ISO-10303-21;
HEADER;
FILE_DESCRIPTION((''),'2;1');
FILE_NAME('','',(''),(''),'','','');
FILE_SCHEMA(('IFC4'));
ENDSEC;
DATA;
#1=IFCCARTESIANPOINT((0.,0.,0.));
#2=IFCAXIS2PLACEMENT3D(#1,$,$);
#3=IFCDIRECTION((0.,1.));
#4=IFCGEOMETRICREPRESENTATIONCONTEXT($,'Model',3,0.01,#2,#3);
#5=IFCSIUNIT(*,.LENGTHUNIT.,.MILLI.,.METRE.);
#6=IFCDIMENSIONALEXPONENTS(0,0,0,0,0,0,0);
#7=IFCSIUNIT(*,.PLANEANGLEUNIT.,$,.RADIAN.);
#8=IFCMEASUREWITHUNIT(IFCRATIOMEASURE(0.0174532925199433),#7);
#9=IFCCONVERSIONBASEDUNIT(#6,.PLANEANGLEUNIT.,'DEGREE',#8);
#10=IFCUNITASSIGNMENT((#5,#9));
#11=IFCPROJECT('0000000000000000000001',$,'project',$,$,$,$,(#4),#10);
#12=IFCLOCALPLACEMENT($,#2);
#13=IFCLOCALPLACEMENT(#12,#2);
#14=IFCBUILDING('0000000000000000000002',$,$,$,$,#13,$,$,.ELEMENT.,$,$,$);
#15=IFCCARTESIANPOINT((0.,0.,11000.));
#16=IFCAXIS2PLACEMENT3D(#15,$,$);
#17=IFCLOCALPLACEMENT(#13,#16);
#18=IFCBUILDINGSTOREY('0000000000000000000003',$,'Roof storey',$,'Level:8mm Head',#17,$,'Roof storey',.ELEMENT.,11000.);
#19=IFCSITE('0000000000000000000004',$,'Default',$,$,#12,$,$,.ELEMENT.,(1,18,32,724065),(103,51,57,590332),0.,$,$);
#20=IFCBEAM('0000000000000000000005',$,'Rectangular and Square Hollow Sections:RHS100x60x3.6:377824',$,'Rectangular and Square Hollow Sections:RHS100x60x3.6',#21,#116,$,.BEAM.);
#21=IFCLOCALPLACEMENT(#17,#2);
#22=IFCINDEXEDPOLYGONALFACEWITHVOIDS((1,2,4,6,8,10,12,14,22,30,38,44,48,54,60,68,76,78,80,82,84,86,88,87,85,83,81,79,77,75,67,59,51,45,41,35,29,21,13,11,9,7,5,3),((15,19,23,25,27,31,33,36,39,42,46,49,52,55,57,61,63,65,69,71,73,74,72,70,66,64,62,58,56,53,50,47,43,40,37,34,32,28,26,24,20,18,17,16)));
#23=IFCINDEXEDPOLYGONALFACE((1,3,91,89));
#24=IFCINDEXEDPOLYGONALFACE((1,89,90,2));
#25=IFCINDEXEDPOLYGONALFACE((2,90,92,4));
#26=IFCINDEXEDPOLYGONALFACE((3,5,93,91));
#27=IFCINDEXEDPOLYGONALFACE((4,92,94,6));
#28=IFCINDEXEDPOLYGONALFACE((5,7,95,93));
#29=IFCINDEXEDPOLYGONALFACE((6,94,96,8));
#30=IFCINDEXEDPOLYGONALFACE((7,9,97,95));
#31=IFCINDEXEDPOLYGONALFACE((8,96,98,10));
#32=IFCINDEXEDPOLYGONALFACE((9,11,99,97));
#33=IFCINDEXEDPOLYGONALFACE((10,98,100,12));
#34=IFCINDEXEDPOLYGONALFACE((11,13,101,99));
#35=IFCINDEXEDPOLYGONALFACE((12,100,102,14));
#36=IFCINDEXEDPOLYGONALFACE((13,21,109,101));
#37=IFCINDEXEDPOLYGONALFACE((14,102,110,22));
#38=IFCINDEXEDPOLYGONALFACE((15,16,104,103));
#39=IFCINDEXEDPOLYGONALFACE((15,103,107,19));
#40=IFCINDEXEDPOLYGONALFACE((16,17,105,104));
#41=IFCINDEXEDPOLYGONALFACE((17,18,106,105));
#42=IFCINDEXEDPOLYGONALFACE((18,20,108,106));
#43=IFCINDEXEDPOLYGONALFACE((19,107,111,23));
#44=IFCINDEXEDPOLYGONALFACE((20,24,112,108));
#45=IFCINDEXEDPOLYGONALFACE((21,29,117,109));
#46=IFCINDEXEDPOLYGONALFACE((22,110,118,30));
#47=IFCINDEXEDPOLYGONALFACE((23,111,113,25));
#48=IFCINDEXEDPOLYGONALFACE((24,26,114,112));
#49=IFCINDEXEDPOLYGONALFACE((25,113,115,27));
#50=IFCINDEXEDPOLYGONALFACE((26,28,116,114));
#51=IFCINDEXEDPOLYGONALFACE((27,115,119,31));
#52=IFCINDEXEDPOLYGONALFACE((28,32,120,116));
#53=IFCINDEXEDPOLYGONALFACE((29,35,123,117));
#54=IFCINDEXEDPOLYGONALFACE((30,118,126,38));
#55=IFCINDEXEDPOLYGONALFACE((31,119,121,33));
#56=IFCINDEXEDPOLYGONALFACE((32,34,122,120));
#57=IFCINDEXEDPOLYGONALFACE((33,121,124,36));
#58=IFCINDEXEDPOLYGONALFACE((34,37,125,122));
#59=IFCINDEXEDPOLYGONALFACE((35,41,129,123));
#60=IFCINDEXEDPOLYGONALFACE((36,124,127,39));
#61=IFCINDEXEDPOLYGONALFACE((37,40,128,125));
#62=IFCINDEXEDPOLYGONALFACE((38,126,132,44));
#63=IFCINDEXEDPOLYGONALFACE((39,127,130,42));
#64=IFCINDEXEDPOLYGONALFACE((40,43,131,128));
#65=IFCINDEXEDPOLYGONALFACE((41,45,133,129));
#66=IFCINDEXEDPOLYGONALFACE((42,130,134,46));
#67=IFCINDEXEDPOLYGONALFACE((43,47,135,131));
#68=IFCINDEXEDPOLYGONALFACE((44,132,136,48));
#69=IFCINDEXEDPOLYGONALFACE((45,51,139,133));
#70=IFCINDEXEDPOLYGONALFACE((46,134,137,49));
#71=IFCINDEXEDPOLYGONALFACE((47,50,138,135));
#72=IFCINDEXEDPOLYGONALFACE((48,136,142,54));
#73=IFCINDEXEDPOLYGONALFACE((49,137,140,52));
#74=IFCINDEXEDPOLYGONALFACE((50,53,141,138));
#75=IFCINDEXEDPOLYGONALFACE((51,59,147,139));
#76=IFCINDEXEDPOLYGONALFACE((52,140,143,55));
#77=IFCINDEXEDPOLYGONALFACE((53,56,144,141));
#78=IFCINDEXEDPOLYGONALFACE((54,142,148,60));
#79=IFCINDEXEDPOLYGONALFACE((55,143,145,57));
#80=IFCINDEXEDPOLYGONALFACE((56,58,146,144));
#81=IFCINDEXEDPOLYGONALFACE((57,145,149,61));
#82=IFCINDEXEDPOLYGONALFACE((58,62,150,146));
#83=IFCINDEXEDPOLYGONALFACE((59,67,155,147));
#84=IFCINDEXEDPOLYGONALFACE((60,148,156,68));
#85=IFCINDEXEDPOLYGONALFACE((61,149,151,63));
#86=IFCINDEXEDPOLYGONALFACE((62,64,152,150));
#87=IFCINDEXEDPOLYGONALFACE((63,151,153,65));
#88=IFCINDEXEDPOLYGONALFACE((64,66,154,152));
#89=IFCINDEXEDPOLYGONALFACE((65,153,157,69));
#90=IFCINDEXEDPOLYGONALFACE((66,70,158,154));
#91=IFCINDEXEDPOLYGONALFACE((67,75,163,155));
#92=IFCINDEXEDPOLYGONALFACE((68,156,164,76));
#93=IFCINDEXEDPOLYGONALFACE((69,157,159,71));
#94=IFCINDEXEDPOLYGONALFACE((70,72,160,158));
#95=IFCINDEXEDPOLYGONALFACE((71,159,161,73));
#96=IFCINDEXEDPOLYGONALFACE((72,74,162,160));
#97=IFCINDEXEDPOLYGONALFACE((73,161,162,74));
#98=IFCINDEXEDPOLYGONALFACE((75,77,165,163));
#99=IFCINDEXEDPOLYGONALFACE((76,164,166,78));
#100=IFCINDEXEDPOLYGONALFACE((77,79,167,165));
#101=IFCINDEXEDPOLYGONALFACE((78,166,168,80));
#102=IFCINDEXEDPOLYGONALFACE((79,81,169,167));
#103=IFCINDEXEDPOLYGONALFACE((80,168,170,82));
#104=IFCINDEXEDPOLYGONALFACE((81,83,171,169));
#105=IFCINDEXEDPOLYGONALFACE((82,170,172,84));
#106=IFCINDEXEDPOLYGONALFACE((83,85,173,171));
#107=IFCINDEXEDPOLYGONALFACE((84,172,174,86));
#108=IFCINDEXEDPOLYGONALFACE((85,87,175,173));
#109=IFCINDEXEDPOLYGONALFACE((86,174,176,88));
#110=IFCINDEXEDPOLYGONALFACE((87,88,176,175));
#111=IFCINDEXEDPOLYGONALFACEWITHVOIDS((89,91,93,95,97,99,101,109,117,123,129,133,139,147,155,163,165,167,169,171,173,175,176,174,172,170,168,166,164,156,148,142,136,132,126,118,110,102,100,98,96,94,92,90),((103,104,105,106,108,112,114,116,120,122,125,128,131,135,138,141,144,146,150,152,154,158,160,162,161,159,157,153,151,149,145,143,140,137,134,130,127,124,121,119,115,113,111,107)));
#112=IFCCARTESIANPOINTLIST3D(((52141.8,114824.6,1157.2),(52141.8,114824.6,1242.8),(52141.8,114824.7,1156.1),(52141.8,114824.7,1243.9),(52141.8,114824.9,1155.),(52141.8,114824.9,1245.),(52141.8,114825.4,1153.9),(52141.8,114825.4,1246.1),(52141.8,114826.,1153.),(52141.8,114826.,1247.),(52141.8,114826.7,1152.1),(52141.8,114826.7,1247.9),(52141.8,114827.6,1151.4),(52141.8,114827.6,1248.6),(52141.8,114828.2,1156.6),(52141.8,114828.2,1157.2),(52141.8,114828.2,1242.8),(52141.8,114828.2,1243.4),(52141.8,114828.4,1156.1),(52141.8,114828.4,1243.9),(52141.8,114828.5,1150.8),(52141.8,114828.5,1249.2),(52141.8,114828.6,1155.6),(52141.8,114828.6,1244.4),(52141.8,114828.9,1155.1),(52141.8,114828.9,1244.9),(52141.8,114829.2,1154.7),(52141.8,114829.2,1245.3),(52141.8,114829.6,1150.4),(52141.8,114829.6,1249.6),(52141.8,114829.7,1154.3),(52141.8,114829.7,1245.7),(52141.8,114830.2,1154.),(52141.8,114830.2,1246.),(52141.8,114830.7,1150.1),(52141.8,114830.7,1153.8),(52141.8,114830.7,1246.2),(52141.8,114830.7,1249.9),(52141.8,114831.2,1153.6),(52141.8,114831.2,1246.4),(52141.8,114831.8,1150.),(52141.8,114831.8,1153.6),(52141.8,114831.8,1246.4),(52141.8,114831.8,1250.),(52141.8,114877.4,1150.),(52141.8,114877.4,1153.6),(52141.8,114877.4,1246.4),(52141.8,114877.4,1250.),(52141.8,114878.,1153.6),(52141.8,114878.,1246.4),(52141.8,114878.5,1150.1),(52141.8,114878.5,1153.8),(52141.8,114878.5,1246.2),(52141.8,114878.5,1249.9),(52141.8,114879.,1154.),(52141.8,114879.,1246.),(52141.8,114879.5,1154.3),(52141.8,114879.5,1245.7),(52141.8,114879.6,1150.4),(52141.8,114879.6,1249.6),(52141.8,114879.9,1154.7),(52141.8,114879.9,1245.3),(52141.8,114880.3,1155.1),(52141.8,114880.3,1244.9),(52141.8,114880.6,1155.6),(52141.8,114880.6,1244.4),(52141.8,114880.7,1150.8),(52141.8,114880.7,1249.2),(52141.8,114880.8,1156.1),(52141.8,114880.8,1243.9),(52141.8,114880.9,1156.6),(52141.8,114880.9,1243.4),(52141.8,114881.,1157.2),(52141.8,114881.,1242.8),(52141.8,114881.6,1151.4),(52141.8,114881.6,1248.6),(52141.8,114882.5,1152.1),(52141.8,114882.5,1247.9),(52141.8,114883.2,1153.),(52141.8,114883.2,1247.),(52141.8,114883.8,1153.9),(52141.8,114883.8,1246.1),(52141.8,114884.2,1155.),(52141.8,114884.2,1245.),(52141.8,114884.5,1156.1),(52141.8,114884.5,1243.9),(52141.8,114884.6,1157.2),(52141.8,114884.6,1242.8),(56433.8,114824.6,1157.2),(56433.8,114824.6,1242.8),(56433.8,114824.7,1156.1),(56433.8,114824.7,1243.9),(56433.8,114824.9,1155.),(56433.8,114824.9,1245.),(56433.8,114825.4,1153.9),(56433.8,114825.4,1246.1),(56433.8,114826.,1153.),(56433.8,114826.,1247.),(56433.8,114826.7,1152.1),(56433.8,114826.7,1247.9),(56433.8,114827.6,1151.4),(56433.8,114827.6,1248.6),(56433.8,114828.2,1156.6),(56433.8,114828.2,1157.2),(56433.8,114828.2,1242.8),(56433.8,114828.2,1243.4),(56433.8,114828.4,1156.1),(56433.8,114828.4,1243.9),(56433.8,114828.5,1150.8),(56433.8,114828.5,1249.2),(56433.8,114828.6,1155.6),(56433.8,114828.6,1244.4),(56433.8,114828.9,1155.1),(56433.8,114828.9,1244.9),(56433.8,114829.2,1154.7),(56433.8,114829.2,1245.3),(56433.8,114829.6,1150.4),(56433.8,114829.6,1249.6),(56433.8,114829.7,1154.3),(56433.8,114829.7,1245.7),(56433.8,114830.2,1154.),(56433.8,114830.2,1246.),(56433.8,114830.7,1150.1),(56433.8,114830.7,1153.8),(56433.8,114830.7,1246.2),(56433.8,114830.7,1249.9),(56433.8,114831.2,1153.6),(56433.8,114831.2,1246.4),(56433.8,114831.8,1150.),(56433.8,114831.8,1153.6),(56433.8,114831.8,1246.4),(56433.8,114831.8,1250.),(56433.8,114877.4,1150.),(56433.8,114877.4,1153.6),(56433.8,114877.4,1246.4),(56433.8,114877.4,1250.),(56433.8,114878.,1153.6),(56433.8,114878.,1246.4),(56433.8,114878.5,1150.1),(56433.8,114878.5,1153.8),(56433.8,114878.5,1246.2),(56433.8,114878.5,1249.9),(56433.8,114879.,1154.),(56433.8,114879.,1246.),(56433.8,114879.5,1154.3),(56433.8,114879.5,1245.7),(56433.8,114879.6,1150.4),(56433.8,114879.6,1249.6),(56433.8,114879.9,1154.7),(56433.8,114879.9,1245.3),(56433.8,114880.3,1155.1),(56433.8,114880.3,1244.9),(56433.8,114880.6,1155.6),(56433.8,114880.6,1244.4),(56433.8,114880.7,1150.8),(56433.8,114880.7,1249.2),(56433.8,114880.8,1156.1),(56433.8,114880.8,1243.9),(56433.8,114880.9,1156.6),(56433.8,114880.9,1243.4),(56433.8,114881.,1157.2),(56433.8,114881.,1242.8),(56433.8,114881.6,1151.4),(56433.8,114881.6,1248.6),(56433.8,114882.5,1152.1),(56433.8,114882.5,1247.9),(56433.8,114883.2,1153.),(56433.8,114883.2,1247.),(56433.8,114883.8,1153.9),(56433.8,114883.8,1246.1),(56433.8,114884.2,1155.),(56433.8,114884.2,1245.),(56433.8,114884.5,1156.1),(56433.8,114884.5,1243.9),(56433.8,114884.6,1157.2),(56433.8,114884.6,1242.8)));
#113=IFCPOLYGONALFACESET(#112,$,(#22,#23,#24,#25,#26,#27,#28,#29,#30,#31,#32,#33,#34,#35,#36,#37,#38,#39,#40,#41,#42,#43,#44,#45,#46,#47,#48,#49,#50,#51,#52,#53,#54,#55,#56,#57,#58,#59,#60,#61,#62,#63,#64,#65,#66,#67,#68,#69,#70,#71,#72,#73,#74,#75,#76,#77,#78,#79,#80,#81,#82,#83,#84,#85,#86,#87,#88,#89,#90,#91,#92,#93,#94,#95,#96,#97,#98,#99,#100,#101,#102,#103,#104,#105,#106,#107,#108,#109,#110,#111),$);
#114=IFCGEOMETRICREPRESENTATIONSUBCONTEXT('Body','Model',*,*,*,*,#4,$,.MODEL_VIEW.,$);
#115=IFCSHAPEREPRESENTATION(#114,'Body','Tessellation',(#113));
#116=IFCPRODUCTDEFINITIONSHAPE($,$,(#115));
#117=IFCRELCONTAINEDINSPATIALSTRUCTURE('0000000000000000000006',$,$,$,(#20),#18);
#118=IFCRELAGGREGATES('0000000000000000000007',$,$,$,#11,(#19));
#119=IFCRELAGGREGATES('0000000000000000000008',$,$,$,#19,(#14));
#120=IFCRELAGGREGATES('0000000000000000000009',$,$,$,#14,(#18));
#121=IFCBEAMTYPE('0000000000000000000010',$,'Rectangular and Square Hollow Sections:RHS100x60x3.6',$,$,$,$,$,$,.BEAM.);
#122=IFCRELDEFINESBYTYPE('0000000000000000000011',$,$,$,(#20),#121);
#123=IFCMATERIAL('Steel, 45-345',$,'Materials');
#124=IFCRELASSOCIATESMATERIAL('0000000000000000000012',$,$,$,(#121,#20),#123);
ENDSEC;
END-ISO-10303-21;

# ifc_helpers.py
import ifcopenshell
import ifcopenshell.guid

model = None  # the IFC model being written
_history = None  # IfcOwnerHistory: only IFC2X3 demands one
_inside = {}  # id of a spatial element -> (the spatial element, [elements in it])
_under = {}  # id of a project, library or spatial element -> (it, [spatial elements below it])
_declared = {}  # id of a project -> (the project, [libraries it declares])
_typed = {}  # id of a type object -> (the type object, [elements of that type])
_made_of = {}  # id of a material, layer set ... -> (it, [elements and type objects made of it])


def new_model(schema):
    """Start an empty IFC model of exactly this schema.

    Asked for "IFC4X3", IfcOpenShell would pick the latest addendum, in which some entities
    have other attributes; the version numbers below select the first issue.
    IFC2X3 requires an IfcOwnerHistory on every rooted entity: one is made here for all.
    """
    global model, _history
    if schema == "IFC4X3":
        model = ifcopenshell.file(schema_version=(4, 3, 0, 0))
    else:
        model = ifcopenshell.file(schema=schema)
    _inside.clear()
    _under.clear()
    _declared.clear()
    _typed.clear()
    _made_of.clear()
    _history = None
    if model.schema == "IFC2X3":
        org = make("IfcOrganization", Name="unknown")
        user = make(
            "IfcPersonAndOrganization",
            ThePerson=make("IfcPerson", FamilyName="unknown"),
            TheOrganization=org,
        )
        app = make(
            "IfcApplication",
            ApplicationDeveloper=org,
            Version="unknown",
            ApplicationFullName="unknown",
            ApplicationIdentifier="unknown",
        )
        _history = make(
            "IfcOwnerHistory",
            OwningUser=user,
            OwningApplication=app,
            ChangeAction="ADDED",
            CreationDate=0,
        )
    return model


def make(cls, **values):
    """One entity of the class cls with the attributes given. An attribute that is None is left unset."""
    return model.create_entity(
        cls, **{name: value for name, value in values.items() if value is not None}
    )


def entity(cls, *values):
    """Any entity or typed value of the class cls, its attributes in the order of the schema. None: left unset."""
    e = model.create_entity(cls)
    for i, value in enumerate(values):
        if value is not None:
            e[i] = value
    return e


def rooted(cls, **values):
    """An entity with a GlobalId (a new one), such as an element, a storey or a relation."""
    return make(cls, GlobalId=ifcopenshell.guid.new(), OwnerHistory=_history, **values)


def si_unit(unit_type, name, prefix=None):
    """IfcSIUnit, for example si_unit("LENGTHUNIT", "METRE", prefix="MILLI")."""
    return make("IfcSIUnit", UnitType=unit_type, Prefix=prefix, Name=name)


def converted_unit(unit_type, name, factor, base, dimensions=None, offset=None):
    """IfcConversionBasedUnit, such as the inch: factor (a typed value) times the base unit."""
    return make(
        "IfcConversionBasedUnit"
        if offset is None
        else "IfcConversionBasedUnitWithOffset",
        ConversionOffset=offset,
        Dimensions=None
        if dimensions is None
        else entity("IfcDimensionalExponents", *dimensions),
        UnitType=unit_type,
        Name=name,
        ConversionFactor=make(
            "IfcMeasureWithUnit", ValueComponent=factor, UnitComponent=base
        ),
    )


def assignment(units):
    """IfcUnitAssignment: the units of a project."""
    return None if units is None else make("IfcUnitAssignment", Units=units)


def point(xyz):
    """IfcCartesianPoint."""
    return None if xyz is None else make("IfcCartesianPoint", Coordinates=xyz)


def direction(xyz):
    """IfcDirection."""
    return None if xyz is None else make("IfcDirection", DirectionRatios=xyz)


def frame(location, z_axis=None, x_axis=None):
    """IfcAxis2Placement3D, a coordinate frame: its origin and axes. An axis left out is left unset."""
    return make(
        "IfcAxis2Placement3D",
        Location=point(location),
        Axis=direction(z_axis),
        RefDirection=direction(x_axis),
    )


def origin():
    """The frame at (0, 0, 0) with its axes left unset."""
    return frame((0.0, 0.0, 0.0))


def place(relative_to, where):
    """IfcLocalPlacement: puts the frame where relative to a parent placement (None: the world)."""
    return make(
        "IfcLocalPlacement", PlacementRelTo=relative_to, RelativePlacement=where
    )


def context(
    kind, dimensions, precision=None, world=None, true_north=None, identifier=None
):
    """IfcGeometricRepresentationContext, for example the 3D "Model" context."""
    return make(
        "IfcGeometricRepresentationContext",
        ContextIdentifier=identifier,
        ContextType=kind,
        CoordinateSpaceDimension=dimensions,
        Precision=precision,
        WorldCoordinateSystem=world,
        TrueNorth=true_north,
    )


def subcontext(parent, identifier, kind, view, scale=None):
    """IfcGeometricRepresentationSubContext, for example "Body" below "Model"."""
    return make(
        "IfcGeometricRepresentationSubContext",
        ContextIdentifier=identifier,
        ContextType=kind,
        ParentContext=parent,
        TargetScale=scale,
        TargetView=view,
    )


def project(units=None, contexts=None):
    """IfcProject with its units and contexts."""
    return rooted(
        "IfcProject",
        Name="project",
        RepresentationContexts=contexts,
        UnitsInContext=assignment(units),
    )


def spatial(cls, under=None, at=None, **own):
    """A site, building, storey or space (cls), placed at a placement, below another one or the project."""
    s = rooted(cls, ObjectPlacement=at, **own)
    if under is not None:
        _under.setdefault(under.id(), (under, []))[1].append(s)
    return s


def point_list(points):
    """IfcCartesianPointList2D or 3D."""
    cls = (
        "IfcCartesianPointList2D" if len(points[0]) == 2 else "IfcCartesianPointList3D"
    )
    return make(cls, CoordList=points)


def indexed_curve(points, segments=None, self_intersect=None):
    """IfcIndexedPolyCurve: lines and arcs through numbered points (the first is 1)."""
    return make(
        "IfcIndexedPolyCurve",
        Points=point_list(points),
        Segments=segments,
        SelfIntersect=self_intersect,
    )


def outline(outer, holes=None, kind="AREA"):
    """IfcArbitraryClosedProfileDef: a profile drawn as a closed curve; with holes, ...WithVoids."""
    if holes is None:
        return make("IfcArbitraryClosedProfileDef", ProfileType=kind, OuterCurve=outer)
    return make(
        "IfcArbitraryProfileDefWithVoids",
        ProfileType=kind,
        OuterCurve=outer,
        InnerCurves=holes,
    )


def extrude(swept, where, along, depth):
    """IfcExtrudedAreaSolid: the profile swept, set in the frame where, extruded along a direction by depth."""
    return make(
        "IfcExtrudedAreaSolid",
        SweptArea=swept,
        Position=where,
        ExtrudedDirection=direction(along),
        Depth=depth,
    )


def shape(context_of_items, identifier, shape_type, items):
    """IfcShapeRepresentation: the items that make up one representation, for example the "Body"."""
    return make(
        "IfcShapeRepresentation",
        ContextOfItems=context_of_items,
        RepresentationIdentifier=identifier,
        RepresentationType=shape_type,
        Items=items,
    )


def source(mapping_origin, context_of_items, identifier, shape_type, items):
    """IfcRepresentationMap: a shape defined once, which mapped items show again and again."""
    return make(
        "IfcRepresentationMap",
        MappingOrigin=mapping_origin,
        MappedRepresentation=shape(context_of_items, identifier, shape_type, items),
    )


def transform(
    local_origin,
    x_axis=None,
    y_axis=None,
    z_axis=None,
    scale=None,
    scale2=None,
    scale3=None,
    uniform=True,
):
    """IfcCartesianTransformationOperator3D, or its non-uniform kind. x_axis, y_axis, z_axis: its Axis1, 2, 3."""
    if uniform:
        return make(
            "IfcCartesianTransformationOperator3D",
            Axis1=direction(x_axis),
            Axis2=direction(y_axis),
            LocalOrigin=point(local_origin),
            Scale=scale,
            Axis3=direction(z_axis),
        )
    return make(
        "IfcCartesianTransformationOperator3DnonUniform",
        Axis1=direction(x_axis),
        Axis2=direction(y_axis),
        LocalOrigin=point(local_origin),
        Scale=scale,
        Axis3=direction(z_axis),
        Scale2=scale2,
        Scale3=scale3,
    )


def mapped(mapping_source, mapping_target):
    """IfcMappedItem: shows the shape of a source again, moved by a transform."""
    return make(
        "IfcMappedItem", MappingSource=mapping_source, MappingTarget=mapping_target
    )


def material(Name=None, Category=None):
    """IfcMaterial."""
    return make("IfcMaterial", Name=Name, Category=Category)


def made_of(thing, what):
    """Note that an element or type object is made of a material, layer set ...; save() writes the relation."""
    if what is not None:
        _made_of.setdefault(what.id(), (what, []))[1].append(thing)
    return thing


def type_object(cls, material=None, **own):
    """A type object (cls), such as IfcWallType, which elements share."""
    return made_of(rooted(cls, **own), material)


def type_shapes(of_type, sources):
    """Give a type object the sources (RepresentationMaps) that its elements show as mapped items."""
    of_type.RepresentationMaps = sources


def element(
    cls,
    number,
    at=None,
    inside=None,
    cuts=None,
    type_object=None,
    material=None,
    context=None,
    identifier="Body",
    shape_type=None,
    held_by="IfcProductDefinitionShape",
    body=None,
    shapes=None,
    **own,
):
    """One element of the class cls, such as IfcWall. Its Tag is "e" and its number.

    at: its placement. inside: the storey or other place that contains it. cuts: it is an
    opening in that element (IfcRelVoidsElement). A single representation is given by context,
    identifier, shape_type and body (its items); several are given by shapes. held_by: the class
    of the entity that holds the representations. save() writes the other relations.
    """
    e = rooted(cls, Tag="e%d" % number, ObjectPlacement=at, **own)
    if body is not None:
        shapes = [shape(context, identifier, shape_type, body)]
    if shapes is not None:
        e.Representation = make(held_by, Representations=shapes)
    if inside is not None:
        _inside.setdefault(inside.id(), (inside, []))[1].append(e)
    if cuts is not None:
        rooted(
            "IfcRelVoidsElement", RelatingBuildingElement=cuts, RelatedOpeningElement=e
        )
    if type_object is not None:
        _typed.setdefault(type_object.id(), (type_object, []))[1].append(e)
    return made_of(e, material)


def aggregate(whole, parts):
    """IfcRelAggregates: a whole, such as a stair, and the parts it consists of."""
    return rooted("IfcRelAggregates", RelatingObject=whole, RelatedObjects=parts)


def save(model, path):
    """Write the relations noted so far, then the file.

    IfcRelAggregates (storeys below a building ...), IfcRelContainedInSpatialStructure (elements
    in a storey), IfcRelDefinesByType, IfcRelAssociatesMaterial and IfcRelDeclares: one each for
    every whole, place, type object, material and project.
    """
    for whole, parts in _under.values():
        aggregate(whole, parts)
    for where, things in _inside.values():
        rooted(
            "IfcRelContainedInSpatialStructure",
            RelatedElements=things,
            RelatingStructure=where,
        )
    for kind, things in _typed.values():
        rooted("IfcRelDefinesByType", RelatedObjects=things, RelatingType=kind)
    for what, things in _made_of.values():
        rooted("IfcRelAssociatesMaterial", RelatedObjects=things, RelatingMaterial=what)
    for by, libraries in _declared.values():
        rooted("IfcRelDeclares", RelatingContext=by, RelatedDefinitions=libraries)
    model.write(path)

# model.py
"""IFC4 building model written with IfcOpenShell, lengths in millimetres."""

from ifc_helpers import new_model, entity, si_unit, converted_unit, direction, frame, origin, place, context, subcontext, project, spatial, indexed_curve, outline, extrude, source, transform, mapped, material, type_object, type_shapes, element, save


model = new_model("IFC4")

# Units and contexts
model_context = context("Model", 3, precision=0.01, world=origin(), true_north=direction((0.0, 1.0)))
body_context = subcontext(model_context, "Body", "Model", "MODEL_VIEW")
ifc_project = project(units=[si_unit("LENGTHUNIT", "METRE", prefix="MILLI"), converted_unit("PLANEANGLEUNIT", "DEGREE", entity("IfcRatioMeasure", 0.0174532925199433), si_unit("PLANEANGLEUNIT", "RADIAN"), dimensions=[0, 0, 0, 0, 0, 0, 0])], contexts=[model_context])

# Site, building, storey
site_placement = place(None, origin())
site = spatial("IfcSite", under=ifc_project, at=site_placement, Name="Default", CompositionType="ELEMENT", RefLatitude=(1, 18, 32, 724065), RefLongitude=(103, 51, 57, 590332), RefElevation=0.0)
building_placement = place(site_placement, origin())
building = spatial("IfcBuilding", under=site, at=building_placement, CompositionType="ELEMENT")
storey_placement = place(building_placement, frame((0.0, 0.0, 11000.0)))
storey = spatial("IfcBuildingStorey", under=building, at=storey_placement, Name="Roof storey", ObjectType="Level:8mm Head", LongName="Roof storey", CompositionType="ELEMENT", Elevation=11000.0)

# Shared definitions
ifc_material = material(Name="Steel, 45-345", Category="Materials")

# Beam
beam_type_1 = type_object("IfcBeamType", Name="Rectangular and Square Hollow Sections:RHS100x60x3.6", PredefinedType="BEAM", material=ifc_material)
shared_shape_1 = source(origin(), body_context, "Body", "SweptSolid", [
    extrude(outline(indexed_curve([(-30.0, -42.8), (-29.9, -43.9), (-29.6, -45.0), (-29.2, -46.1), (-28.6, -47.0), (-27.9, -47.9), (-27.0, -48.6), (-26.1, -49.2), (-25.0, -49.6), (-23.9, -49.9), (-22.8, -50.0), (22.8, -50.0), (23.9, -49.9), (25.0, -49.6), (26.1, -49.2), (27.0, -48.6), (27.9, -47.9), (28.6, -47.0), (29.2, -46.1), (29.6, -45.0), (29.9, -43.9), (30.0, -42.8), (30.0, 42.8), (29.9, 43.9), (29.6, 45.0), (29.2, 46.1), (28.6, 47.0), (27.9, 47.9), (27.0, 48.6), (26.1, 49.2), (25.0, 49.6), (23.9, 49.9), (22.8, 50.0), (-22.8, 50.0), (-23.9, 49.9), (-25.0, 49.6), (-26.1, 49.2), (-27.0, 48.6), (-27.9, 47.9), (-28.6, 47.0), (-29.2, 46.1), (-29.6, 45.0), (-29.9, 43.9), (-30.0, 42.8), (-30.0, -42.8)], self_intersect=False), holes=[indexed_curve([(22.8, -46.4), (-22.8, -46.4), (-23.4, -46.4), (-23.9, -46.2), (-24.4, -46.0), (-24.9, -45.7), (-25.3, -45.3), (-25.7, -44.9), (-26.0, -44.4), (-26.2, -43.9), (-26.4, -43.4), (-26.4, -42.8), (-26.4, 42.8), (-26.4, 43.4), (-26.2, 43.9), (-26.0, 44.4), (-25.7, 44.9), (-25.3, 45.3), (-24.9, 45.7), (-24.4, 46.0), (-23.9, 46.2), (-23.4, 46.4), (-22.8, 46.4), (22.8, 46.4), (23.4, 46.4), (23.9, 46.2), (24.4, 46.0), (24.9, 45.7), (25.3, 45.3), (25.7, 44.9), (26.0, 44.4), (26.2, 43.9), (26.4, 43.4), (26.4, 42.8), (26.4, -42.8), (26.4, -43.4), (26.2, -43.9), (26.0, -44.4), (25.7, -44.9), (25.3, -45.3), (24.9, -45.7), (24.4, -46.0), (23.9, -46.2), (23.4, -46.4), (22.8, -46.4)], self_intersect=False)]), frame((-2152.5, 0.0, 0.0), z_axis=(1.0, 0.0, 0.0), x_axis=(0.0, -1.0, 0.0)), (0.0, 0.0, 1.0), 4292.0),
])
type_shapes(beam_type_1, [shared_shape_1])
for number, where, name in (
    (1, (54294.3, 114854.6, 1200.0), "Rectangular and Square Hollow Sections:RHS100x60x3.6:377824"),
):
    element("IfcBeam", number, at=place(storey_placement, frame(where)), inside=storey, type_object=beam_type_1, material=ifc_material, Name=name, ObjectType="Rectangular and Square Hollow Sections:RHS100x60x3.6", PredefinedType="BEAM", context=body_context, shape_type="MappedRepresentation", body=[
        mapped(shared_shape_1, transform((0.0, 0.0, 0.0), scale=1.0)),
    ])

save(model, "model.ifc")
